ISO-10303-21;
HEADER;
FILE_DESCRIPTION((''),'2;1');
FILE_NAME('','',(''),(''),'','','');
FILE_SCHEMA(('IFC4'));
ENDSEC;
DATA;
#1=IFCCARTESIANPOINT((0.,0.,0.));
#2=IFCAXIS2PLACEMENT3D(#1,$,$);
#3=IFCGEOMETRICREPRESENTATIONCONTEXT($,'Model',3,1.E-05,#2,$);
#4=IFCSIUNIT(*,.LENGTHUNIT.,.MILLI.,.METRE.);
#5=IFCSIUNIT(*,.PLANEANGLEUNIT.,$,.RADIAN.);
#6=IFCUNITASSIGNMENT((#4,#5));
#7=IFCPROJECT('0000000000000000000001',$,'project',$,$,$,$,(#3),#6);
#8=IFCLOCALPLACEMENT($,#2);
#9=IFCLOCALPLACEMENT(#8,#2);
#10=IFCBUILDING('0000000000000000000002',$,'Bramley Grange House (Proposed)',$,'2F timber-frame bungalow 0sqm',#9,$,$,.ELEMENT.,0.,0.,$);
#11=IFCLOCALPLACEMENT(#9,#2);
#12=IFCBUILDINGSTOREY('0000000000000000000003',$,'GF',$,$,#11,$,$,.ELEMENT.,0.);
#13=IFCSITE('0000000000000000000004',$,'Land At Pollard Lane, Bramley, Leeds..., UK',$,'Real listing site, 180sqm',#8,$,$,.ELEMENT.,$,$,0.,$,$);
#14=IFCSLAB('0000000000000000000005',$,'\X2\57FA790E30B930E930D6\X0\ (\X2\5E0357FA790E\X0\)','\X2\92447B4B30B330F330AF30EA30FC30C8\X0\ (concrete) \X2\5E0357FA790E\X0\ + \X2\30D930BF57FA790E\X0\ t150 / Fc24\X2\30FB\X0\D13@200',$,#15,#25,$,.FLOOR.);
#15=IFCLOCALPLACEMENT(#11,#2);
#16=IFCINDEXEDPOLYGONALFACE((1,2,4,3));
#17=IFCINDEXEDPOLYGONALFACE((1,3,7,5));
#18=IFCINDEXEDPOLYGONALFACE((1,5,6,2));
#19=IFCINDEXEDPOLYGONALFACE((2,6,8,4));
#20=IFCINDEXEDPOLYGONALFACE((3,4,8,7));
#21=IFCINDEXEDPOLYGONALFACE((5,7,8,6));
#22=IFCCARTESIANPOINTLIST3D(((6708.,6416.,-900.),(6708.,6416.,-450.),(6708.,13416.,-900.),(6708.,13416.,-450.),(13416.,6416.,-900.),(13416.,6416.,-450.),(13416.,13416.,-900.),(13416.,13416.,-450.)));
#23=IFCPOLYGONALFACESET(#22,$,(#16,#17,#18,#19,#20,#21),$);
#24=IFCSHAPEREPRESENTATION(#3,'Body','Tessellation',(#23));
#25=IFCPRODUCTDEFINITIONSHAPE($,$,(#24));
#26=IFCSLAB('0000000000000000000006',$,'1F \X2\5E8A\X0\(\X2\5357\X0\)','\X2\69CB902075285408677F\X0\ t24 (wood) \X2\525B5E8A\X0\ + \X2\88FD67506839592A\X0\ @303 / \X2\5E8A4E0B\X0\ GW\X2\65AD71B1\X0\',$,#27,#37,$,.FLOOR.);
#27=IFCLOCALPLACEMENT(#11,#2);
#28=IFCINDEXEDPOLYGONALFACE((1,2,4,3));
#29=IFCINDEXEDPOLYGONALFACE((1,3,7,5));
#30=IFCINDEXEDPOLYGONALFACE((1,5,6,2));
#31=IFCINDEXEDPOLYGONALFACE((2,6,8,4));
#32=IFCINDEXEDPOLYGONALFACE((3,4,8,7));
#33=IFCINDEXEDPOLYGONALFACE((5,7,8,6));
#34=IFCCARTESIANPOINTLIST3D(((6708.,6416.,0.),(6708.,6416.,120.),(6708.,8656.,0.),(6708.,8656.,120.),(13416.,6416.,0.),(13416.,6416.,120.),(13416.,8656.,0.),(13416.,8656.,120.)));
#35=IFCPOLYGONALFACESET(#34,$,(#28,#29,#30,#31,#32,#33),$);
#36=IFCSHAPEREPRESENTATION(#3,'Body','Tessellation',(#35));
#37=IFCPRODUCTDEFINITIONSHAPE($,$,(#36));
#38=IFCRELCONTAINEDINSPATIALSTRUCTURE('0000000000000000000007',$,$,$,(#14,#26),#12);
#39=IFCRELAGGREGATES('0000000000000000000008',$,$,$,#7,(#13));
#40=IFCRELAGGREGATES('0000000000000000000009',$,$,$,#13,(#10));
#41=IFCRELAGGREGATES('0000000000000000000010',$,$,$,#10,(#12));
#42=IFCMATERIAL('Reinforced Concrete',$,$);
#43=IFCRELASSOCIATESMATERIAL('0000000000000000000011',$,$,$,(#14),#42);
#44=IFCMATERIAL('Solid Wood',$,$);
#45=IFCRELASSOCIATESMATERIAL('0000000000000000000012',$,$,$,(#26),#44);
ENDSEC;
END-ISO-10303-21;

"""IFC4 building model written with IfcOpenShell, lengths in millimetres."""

from ifc_helpers import new_model, si_unit, frame, frame_2d, origin, place, context, project, spatial, rectangle, extrude, material, element, save


model = new_model("IFC4")

# Units and contexts
model_context = context("Model", 3, precision=1e-05, world=origin())
ifc_project = project(units=[si_unit("LENGTHUNIT", "METRE", prefix="MILLI"), si_unit("PLANEANGLEUNIT", "RADIAN")], contexts=[model_context])

# Site, building, storey
site_placement = place(None, origin())
site = spatial("IfcSite", under=ifc_project, at=site_placement, Name="Land At Pollard Lane, Bramley, Leeds..., UK", ObjectType="Real listing site, 180sqm", CompositionType="ELEMENT", RefElevation=0.0)
building_placement = place(site_placement, origin())
building = spatial("IfcBuilding", under=site, at=building_placement, Name="Bramley Grange House (Proposed)", ObjectType="2F timber-frame bungalow 0sqm", CompositionType="ELEMENT", ElevationOfRefHeight=0.0, ElevationOfTerrain=0.0)
storey_placement = place(building_placement, origin())
storey = spatial("IfcBuildingStorey", under=building, at=storey_placement, Name="GF", CompositionType="ELEMENT", Elevation=0.0)

# Slabs
ifc_material_1 = material(Name="Reinforced Concrete")
slab_1_placement = place(storey_placement, frame((3354.0, 3208.0, -450.0)))
element("IfcSlab", 1, at=slab_1_placement, inside=storey, material=ifc_material_1, Name="基礎スラブ (布基礎)", Description="鉄筋コンクリート (concrete) 布基礎 + ベタ基礎 t150 / Fc24・D13@200", PredefinedType="FLOOR", context=model_context, shape_type="SweptSolid", body=[
    extrude(rectangle(XDim=6708.0, YDim=7000.0, at=frame_2d((3354.0, 3500.0))), frame((3354.0, 3208.0, -450.0)), (0.0, 0.0, 1.0), 450.0),
])
ifc_material_2 = material(Name="Solid Wood")
slab_2_placement = place(storey_placement, frame((3354.0, 3208.0, 0.0)))
element("IfcSlab", 2, at=slab_2_placement, inside=storey, material=ifc_material_2, Name="1F 床(南)", Description="構造用合板 t24 (wood) 剛床 + 製材根太 @303 / 床下 GW断熱", PredefinedType="FLOOR", context=model_context, shape_type="SweptSolid", body=[
    extrude(rectangle(XDim=6708.0, YDim=2240.0, at=frame_2d((3354.0, 1120.0))), frame((3354.0, 3208.0, 0.0)), (0.0, 0.0, 1.0), 120.0),
])

save(model, "model.ifc")
